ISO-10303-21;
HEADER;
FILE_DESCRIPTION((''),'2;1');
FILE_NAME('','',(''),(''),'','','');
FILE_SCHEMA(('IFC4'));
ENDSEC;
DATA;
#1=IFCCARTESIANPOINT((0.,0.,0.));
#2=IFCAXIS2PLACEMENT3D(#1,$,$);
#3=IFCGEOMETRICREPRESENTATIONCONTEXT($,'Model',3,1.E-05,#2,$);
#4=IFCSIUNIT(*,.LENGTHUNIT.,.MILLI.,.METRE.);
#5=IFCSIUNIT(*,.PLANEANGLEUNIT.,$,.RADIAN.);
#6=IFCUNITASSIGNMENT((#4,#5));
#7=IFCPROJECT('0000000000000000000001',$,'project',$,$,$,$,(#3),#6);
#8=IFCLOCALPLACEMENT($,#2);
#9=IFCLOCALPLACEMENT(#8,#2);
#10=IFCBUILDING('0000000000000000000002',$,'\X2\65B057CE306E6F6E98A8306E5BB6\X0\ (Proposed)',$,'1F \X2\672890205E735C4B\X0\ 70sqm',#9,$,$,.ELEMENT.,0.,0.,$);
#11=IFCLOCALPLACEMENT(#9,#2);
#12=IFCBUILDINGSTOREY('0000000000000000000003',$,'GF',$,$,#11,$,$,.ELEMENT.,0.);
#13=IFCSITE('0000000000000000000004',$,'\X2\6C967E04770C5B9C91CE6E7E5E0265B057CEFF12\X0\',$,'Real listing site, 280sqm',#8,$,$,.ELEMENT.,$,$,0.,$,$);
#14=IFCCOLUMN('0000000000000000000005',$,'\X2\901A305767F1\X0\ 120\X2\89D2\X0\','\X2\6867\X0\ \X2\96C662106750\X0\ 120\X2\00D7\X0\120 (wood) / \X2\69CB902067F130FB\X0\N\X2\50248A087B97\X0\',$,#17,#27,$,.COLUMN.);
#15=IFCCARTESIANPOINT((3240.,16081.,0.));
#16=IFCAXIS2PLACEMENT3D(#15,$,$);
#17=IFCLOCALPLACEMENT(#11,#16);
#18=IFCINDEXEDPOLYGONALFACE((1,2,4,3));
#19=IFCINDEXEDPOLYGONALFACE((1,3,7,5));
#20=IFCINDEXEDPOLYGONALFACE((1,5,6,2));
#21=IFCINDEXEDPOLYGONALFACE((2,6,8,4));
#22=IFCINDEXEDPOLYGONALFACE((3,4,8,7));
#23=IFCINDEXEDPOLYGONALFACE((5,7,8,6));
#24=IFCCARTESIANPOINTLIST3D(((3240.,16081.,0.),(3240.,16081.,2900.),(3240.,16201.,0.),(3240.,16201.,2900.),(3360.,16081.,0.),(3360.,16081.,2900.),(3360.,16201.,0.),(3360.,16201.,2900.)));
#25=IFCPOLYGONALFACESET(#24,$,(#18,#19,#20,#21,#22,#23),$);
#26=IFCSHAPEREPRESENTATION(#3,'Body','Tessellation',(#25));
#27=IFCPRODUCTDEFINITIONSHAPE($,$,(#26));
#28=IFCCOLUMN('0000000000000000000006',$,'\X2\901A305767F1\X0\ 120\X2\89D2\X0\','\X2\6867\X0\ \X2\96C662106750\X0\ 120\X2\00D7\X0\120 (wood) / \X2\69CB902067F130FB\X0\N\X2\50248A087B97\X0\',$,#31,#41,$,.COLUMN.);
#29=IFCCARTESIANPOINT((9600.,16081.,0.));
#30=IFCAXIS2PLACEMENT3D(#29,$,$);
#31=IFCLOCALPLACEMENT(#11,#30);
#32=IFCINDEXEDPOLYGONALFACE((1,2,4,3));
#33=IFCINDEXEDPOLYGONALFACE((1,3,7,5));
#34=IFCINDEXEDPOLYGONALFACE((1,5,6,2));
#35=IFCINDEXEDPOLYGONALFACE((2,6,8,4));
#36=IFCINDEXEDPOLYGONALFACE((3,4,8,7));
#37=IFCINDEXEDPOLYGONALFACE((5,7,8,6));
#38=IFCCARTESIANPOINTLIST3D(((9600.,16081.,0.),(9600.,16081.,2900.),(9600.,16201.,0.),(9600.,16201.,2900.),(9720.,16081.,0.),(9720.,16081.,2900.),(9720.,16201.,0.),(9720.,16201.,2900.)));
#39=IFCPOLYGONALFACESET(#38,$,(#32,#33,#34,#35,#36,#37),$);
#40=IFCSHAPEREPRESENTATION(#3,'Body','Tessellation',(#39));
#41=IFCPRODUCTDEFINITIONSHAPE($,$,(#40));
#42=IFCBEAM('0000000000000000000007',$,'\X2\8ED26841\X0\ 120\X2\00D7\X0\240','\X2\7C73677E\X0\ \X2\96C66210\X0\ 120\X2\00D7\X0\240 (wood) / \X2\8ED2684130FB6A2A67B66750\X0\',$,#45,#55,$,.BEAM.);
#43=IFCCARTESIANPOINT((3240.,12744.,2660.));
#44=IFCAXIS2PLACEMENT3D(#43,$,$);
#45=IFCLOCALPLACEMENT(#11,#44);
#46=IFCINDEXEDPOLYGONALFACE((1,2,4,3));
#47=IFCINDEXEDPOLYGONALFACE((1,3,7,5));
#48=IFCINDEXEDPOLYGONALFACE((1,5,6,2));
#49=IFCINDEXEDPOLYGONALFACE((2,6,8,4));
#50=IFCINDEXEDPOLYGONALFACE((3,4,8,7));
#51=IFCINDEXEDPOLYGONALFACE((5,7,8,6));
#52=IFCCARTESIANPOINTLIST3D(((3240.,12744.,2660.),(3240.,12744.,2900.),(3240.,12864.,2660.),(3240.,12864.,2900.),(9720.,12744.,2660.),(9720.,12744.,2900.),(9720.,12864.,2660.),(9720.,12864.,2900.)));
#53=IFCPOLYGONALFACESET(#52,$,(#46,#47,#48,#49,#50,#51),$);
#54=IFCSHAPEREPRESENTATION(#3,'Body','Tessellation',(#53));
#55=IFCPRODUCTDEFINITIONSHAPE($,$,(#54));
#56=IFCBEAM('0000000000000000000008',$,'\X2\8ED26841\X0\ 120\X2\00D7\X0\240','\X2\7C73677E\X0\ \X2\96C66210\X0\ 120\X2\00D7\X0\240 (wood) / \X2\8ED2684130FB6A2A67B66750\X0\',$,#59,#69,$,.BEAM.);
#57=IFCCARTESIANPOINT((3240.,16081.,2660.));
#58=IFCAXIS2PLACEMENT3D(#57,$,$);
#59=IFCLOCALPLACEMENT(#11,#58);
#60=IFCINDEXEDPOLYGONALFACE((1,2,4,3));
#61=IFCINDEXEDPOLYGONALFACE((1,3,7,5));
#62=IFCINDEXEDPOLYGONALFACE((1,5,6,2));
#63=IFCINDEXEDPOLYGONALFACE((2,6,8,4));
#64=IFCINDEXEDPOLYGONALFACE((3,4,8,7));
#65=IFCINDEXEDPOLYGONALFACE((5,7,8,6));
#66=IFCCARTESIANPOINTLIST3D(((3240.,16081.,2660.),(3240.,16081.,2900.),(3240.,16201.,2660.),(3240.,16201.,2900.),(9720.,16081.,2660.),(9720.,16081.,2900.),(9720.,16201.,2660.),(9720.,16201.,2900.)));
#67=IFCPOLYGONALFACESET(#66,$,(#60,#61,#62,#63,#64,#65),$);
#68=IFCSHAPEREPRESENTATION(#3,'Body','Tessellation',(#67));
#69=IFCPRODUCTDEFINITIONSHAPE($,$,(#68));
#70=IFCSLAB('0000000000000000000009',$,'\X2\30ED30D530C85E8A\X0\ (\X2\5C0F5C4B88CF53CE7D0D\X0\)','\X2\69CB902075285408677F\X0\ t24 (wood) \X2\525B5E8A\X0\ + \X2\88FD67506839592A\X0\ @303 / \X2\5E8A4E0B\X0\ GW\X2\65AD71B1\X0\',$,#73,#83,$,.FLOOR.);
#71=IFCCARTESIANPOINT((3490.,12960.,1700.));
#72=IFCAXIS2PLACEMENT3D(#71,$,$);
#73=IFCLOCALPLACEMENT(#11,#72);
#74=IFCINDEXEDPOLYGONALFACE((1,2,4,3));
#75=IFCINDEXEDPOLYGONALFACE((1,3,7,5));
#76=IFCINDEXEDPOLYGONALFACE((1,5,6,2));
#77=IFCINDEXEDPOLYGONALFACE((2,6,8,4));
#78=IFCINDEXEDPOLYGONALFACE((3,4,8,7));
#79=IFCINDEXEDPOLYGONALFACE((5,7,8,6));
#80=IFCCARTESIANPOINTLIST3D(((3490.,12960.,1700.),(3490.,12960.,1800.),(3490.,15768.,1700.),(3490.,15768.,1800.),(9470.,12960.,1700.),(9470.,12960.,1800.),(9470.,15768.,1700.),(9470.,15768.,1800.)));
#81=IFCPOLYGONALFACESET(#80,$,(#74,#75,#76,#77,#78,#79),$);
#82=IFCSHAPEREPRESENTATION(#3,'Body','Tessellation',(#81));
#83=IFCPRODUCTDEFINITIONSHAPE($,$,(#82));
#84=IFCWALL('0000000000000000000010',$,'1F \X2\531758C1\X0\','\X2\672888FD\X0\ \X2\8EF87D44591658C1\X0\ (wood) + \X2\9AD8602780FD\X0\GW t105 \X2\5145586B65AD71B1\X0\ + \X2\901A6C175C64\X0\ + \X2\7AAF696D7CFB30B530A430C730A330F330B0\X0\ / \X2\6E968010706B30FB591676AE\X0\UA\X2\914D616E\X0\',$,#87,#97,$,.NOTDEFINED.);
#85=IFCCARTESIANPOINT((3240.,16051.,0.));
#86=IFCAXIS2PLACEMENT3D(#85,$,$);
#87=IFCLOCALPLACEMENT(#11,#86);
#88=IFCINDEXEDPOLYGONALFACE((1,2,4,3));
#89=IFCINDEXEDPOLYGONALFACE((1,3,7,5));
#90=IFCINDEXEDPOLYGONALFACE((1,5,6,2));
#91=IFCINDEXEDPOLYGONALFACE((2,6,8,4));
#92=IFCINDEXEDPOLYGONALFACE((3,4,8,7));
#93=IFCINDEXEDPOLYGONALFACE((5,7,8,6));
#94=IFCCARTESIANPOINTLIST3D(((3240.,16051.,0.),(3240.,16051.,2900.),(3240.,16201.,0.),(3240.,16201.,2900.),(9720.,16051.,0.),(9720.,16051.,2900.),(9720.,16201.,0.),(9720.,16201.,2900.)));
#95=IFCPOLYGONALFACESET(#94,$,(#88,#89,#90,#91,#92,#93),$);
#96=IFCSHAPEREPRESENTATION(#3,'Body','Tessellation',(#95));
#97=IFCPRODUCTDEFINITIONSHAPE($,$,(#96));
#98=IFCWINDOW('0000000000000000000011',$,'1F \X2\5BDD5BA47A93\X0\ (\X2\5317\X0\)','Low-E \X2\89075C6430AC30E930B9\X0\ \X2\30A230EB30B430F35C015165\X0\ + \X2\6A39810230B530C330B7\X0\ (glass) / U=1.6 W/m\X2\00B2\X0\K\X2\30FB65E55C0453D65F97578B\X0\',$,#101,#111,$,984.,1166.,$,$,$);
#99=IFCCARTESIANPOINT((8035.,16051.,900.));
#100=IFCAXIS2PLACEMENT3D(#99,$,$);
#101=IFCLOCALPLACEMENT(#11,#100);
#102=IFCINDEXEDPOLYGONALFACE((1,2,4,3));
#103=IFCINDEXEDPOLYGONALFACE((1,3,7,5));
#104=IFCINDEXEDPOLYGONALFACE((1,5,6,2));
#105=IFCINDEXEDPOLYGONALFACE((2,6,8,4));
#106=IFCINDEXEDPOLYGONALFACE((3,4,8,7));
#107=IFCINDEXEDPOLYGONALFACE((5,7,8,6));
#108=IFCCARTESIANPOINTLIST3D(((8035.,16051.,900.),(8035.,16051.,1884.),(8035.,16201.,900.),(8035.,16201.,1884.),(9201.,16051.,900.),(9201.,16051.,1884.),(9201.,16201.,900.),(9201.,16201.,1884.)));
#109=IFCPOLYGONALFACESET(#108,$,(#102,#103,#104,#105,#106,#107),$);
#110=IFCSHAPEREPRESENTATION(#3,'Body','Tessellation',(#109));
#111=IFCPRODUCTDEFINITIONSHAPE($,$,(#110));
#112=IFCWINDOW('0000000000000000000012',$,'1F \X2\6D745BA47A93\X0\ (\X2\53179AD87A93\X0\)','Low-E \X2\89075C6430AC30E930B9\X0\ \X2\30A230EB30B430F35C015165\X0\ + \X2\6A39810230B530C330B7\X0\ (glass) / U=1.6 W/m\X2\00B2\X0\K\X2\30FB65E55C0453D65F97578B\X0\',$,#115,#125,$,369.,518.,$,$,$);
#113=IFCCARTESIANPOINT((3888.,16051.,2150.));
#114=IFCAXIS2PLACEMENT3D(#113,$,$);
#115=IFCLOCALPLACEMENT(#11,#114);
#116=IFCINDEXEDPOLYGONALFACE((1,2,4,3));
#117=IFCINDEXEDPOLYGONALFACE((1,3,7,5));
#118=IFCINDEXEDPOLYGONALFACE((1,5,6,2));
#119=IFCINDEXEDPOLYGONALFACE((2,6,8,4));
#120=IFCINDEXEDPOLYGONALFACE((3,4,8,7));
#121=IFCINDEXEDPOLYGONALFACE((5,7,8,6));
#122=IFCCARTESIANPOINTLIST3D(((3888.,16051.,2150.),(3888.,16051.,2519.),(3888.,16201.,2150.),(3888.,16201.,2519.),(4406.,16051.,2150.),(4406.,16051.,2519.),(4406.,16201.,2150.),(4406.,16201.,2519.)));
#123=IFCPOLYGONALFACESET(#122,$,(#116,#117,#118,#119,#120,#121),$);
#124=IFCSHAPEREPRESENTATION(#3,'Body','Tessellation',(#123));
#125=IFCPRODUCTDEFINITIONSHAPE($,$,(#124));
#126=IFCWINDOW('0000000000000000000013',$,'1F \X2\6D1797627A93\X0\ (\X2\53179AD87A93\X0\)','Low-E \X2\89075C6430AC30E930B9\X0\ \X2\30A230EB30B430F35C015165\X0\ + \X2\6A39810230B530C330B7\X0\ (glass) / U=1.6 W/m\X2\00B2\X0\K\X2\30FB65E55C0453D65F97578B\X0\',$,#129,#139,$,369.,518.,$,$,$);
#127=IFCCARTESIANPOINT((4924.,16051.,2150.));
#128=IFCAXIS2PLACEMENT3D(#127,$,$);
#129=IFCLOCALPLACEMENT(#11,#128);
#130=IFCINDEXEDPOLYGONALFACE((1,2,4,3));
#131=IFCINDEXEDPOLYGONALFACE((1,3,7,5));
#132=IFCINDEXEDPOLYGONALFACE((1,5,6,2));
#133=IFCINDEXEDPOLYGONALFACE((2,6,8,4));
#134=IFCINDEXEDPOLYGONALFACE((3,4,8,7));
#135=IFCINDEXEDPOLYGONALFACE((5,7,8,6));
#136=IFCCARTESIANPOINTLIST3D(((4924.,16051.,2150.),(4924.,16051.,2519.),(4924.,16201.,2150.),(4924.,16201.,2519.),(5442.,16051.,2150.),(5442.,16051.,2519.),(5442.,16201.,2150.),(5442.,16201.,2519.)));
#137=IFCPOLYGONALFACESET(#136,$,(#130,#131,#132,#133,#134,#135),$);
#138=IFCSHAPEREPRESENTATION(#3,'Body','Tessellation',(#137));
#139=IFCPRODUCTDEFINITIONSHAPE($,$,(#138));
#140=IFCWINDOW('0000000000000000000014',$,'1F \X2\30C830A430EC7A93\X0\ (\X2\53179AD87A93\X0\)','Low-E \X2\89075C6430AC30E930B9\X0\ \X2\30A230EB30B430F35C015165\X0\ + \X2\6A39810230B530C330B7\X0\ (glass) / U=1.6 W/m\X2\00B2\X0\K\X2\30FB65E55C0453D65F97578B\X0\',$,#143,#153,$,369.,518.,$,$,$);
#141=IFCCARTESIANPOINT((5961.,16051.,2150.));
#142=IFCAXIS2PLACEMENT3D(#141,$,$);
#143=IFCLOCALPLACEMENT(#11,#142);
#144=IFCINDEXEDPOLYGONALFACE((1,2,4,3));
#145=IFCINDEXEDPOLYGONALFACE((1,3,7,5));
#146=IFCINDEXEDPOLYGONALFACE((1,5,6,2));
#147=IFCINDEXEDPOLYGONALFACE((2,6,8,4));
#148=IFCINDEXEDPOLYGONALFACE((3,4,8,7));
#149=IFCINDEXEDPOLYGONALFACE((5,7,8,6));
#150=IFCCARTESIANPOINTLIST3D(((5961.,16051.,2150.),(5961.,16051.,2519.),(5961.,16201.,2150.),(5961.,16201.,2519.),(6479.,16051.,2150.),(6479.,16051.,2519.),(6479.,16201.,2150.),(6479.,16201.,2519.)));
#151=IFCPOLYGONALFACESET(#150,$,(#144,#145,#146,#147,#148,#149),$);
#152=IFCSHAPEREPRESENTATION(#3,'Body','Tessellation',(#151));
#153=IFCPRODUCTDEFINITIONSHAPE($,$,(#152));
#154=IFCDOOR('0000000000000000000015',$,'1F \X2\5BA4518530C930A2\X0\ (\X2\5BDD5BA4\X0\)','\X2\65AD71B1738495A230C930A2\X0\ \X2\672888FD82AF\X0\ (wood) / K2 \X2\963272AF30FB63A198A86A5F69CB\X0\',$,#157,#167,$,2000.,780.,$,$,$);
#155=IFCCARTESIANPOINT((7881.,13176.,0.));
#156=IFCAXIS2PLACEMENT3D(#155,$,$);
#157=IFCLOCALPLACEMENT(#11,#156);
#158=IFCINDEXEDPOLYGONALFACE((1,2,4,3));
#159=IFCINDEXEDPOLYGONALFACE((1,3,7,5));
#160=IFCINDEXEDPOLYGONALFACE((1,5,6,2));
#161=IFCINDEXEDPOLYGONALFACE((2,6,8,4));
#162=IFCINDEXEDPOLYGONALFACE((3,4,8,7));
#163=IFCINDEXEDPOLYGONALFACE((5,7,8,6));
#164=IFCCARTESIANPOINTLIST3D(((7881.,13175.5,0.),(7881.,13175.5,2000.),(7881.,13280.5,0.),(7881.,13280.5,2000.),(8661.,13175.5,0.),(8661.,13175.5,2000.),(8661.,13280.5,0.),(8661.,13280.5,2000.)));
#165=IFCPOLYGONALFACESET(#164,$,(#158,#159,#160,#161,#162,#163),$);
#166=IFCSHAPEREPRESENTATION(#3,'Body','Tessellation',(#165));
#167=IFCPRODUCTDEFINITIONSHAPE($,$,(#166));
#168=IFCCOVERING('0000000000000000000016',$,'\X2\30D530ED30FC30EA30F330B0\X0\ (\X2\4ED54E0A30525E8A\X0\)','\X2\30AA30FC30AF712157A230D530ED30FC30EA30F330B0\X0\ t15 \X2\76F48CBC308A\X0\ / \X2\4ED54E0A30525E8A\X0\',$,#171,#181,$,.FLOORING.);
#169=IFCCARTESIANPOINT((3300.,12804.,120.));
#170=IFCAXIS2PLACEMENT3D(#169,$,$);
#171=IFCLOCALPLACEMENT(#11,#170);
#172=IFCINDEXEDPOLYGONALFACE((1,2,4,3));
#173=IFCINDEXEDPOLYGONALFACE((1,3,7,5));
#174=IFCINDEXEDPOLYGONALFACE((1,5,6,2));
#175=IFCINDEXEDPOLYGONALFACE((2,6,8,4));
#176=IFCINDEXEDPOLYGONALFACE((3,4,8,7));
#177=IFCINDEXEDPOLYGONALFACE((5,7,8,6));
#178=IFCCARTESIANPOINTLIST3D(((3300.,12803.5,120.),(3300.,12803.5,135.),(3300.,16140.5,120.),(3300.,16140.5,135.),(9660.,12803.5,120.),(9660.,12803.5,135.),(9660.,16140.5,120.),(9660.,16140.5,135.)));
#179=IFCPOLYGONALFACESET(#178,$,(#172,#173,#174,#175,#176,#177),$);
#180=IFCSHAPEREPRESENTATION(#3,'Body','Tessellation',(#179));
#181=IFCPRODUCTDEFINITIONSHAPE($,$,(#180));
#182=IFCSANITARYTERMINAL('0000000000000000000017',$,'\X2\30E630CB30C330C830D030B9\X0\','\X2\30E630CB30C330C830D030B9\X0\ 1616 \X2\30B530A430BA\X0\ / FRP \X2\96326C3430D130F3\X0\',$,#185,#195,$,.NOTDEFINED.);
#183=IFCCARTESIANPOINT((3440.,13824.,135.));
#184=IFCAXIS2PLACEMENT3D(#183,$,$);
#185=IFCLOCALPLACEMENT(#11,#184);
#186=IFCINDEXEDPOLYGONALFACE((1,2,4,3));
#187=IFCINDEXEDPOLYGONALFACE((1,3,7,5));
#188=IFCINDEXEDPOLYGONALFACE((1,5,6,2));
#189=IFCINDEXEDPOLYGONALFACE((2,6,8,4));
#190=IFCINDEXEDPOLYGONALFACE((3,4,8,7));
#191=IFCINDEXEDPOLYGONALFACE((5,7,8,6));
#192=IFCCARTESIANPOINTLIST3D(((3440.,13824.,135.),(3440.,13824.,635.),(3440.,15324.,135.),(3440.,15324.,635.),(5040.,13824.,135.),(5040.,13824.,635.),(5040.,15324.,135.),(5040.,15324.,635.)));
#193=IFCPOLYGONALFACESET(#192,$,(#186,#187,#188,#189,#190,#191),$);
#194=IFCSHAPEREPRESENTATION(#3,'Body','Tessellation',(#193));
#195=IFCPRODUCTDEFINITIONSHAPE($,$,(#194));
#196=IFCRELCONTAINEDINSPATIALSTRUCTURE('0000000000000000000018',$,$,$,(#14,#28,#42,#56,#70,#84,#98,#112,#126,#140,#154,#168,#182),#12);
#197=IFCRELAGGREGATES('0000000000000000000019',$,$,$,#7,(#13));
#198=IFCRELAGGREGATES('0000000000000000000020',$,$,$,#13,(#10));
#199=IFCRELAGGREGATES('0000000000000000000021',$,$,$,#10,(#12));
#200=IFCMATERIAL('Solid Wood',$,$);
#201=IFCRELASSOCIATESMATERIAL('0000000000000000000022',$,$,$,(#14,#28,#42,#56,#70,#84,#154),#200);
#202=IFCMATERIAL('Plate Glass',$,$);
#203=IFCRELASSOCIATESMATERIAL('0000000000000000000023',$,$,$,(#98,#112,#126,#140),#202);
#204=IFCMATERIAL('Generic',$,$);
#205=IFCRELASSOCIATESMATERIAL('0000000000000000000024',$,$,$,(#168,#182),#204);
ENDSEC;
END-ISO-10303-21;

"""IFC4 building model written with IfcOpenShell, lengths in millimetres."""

from ifc_helpers import new_model, si_unit, frame, frame_2d, origin, place, context, project, spatial, rectangle, extrude, material, element, fill, save


model = new_model("IFC4")

# Units and contexts
model_context = context("Model", 3, precision=1e-05, world=origin())
ifc_project = project(units=[si_unit("LENGTHUNIT", "METRE", prefix="MILLI"), si_unit("PLANEANGLEUNIT", "RADIAN")], contexts=[model_context])

# Site, building, storey
site_placement = place(None, origin())
site = spatial("IfcSite", under=ifc_project, at=site_placement, Name="沖縄県宜野湾市新城２", ObjectType="Real listing site, 280sqm", CompositionType="ELEMENT", RefElevation=0.0)
building_placement = place(site_placement, origin())
building = spatial("IfcBuilding", under=site, at=building_placement, Name="新城の潮風の家 (Proposed)", ObjectType="1F 木造平屋 70sqm", CompositionType="ELEMENT", ElevationOfRefHeight=0.0, ElevationOfTerrain=0.0)
storey_placement = place(building_placement, origin())
storey = spatial("IfcBuildingStorey", under=building, at=storey_placement, Name="GF", CompositionType="ELEMENT", Elevation=0.0)

# Columns
ifc_material_1 = material(Name="Solid Wood")
column_1_placement = place(storey_placement, frame((3240.0, 16081.0, 0.0)))
element("IfcColumn", 1, at=column_1_placement, inside=storey, material=ifc_material_1, Name="通し柱 120角", Description="桧 集成材 120×120 (wood) / 構造柱・N値計算", PredefinedType="COLUMN", context=model_context, shape_type="SweptSolid", body=[
    extrude(rectangle(XDim=120.0, YDim=120.0, at=frame_2d((60.0, 60.0))), frame((3240.0, 16081.0, 0.0)), (0.0, 0.0, 1.0), 2900.0),
])
column_2_placement = place(storey_placement, frame((9600.0, 16081.0, 0.0)))
element("IfcColumn", 2, at=column_2_placement, inside=storey, material=ifc_material_1, Name="通し柱 120角", Description="桧 集成材 120×120 (wood) / 構造柱・N値計算", PredefinedType="COLUMN", context=model_context, shape_type="SweptSolid", body=[
    extrude(rectangle(XDim=120.0, YDim=120.0, at=frame_2d((60.0, 60.0))), frame((9600.0, 16081.0, 0.0)), (0.0, 0.0, 1.0), 2900.0),
])

# Beams
beam_1_placement = place(storey_placement, frame((3240.0, 12744.0, 2660.0)))
element("IfcBeam", 3, at=beam_1_placement, inside=storey, material=ifc_material_1, Name="軒桁 120×240", Description="米松 集成 120×240 (wood) / 軒桁・横架材", PredefinedType="BEAM", context=model_context, shape_type="SweptSolid", body=[
    extrude(rectangle(XDim=6480.0, YDim=120.0, at=frame_2d((3240.0, 60.0))), frame((3240.0, 12744.0, 2660.0)), (0.0, 0.0, 1.0), 240.0),
])
beam_2_placement = place(storey_placement, frame((3240.0, 16081.0, 2660.0)))
element("IfcBeam", 4, at=beam_2_placement, inside=storey, material=ifc_material_1, Name="軒桁 120×240", Description="米松 集成 120×240 (wood) / 軒桁・横架材", PredefinedType="BEAM", context=model_context, shape_type="SweptSolid", body=[
    extrude(rectangle(XDim=6480.0, YDim=120.0, at=frame_2d((3240.0, 60.0))), frame((3240.0, 16081.0, 2660.0)), (0.0, 0.0, 1.0), 240.0),
])

# Slab
slab_placement = place(storey_placement, frame((3490.0, 12960.0, 1700.0)))
element("IfcSlab", 5, at=slab_placement, inside=storey, material=ifc_material_1, Name="ロフト床 (小屋裏収納)", Description="構造用合板 t24 (wood) 剛床 + 製材根太 @303 / 床下 GW断熱", PredefinedType="FLOOR", context=model_context, shape_type="SweptSolid", body=[
    extrude(rectangle(XDim=5980.0, YDim=2808.0, at=frame_2d((2990.0, 1404.0))), frame((3490.0, 12960.0, 1700.0)), (0.0, 0.0, 1.0), 100.0),
])

# Wall, openings, windows
wall_1_placement = place(storey_placement, frame((3240.0, 16051.0, 0.0)))
wall_1 = element("IfcWall", 6, at=wall_1_placement, inside=storey, material=ifc_material_1, Name="1F 北壁", Description="木製 軸組外壁 (wood) + 高性能GW t105 充填断熱 + 通気層 + 窯業系サイディング / 準耐火・外皮UA配慮", PredefinedType="NOTDEFINED", context=model_context, shape_type="SweptSolid", body=[
    extrude(rectangle(XDim=6480.0, YDim=150.0, at=frame_2d((3240.0, 75.0))), frame((3240.0, 16051.0, 0.0)), (0.0, 0.0, 1.0), 2900.0),
])
opening_1_placement = place(storey_placement, frame((8035.0, 16051.0, 900.0)))
opening_1 = element("IfcOpeningElement", 7, at=opening_1_placement, cuts=wall_1, PredefinedType="NOTDEFINED", context=model_context, shape_type="SweptSolid", body=[
    extrude(rectangle(XDim=1166.0, YDim=150.0, at=frame_2d((583.0, 75.0))), frame((8035.0, 16051.0, 900.0)), (0.0, 0.0, 1.0), 984.0),
])
opening_2_placement = place(storey_placement, frame((3888.0, 16051.0, 2150.0)))
opening_2 = element("IfcOpeningElement", 8, at=opening_2_placement, cuts=wall_1, PredefinedType="NOTDEFINED", context=model_context, shape_type="SweptSolid", body=[
    extrude(rectangle(XDim=518.0, YDim=150.0, at=frame_2d((259.0, 75.0))), frame((3888.0, 16051.0, 2150.0)), (0.0, 0.0, 1.0), 369.0),
])
opening_3_placement = place(storey_placement, frame((4924.0, 16051.0, 2150.0)))
opening_3 = element("IfcOpeningElement", 9, at=opening_3_placement, cuts=wall_1, PredefinedType="NOTDEFINED", context=model_context, shape_type="SweptSolid", body=[
    extrude(rectangle(XDim=518.0, YDim=150.0, at=frame_2d((259.0, 75.0))), frame((4924.0, 16051.0, 2150.0)), (0.0, 0.0, 1.0), 369.0),
])
opening_4_placement = place(storey_placement, frame((5961.0, 16051.0, 2150.0)))
opening_4 = element("IfcOpeningElement", 10, at=opening_4_placement, cuts=wall_1, PredefinedType="NOTDEFINED", context=model_context, shape_type="SweptSolid", body=[
    extrude(rectangle(XDim=518.0, YDim=150.0, at=frame_2d((259.0, 75.0))), frame((5961.0, 16051.0, 2150.0)), (0.0, 0.0, 1.0), 369.0),
])
ifc_material_2 = material(Name="Plate Glass")
window_1_placement = place(storey_placement, frame((8035.0, 16051.0, 900.0)))
window_1 = element("IfcWindow", 11, at=window_1_placement, inside=storey, material=ifc_material_2, Name="1F 寝室窓 (北)", Description="Low-E 複層ガラス アルゴン封入 + 樹脂サッシ (glass) / U=1.6 W/m²K・日射取得型", OverallHeight=984.0, OverallWidth=1166.0, context=model_context, shape_type="SweptSolid", body=[
    extrude(rectangle(XDim=1166.0, YDim=150.0, at=frame_2d((583.0, 75.0))), frame((8035.0, 16051.0, 900.0)), (0.0, 0.0, 1.0), 984.0),
])
fill(opening_1, window_1)
window_2_placement = place(storey_placement, frame((3888.0, 16051.0, 2150.0)))
window_2 = element("IfcWindow", 12, at=window_2_placement, inside=storey, material=ifc_material_2, Name="1F 浴室窓 (北高窓)", Description="Low-E 複層ガラス アルゴン封入 + 樹脂サッシ (glass) / U=1.6 W/m²K・日射取得型", OverallHeight=369.0, OverallWidth=518.0, context=model_context, shape_type="SweptSolid", body=[
    extrude(rectangle(XDim=518.0, YDim=150.0, at=frame_2d((259.0, 75.0))), frame((3888.0, 16051.0, 2150.0)), (0.0, 0.0, 1.0), 369.0),
])
fill(opening_2, window_2)
window_3_placement = place(storey_placement, frame((4924.0, 16051.0, 2150.0)))
window_3 = element("IfcWindow", 13, at=window_3_placement, inside=storey, material=ifc_material_2, Name="1F 洗面窓 (北高窓)", Description="Low-E 複層ガラス アルゴン封入 + 樹脂サッシ (glass) / U=1.6 W/m²K・日射取得型", OverallHeight=369.0, OverallWidth=518.0, context=model_context, shape_type="SweptSolid", body=[
    extrude(rectangle(XDim=518.0, YDim=150.0, at=frame_2d((259.0, 75.0))), frame((4924.0, 16051.0, 2150.0)), (0.0, 0.0, 1.0), 369.0),
])
fill(opening_3, window_3)
window_4_placement = place(storey_placement, frame((5961.0, 16051.0, 2150.0)))
window_4 = element("IfcWindow", 14, at=window_4_placement, inside=storey, material=ifc_material_2, Name="1F トイレ窓 (北高窓)", Description="Low-E 複層ガラス アルゴン封入 + 樹脂サッシ (glass) / U=1.6 W/m²K・日射取得型", OverallHeight=369.0, OverallWidth=518.0, context=model_context, shape_type="SweptSolid", body=[
    extrude(rectangle(XDim=518.0, YDim=150.0, at=frame_2d((259.0, 75.0))), frame((5961.0, 16051.0, 2150.0)), (0.0, 0.0, 1.0), 369.0),
])
fill(opening_4, window_4)

# Door
door_1_placement = place(storey_placement, frame((7881.0, 13176.0, 0.0)))
element("IfcDoor", 15, at=door_1_placement, inside=storey, material=ifc_material_1, Name="1F 室内ドア (寝室)", Description="断熱玄関ドア 木製芯 (wood) / K2 防犯・採風機構", OverallHeight=2000.0, OverallWidth=780.0, context=model_context, shape_type="SweptSolid", body=[
    extrude(rectangle(XDim=780.0, YDim=105.0, at=frame_2d((390.0, 52.0))), frame((7881.0, 13176.0, 0.0)), (0.0, 0.0, 1.0), 2000.0),
])

# Covering
ifc_material_3 = material(Name="Generic")
covering_placement = place(storey_placement, frame((3300.0, 12804.0, 120.0)))
element("IfcCovering", 16, at=covering_placement, inside=storey, material=ifc_material_3, Name="フローリング (仕上げ床)", Description="オーク無垢フローリング t15 直貼り / 仕上げ床", PredefinedType="FLOORING", context=model_context, shape_type="SweptSolid", body=[
    extrude(rectangle(XDim=6360.0, YDim=3337.0, at=frame_2d((3180.0, 1668.0))), frame((3300.0, 12804.0, 120.0)), (0.0, 0.0, 1.0), 15.0),
])

# Sanitary terminal
sanitary_terminal_1_placement = place(storey_placement, frame((3440.0, 13824.0, 135.0)))
element("IfcSanitaryTerminal", 17, at=sanitary_terminal_1_placement, inside=storey, material=ifc_material_3, Name="ユニットバス", Description="ユニットバス 1616 サイズ / FRP 防水パン", PredefinedType="NOTDEFINED", context=model_context, shape_type="SweptSolid", body=[
    extrude(rectangle(XDim=1600.0, YDim=1500.0, at=frame_2d((800.0, 750.0))), frame((3440.0, 13824.0, 135.0)), (0.0, 0.0, 1.0), 500.0),
])

save(model, "model.ifc")
